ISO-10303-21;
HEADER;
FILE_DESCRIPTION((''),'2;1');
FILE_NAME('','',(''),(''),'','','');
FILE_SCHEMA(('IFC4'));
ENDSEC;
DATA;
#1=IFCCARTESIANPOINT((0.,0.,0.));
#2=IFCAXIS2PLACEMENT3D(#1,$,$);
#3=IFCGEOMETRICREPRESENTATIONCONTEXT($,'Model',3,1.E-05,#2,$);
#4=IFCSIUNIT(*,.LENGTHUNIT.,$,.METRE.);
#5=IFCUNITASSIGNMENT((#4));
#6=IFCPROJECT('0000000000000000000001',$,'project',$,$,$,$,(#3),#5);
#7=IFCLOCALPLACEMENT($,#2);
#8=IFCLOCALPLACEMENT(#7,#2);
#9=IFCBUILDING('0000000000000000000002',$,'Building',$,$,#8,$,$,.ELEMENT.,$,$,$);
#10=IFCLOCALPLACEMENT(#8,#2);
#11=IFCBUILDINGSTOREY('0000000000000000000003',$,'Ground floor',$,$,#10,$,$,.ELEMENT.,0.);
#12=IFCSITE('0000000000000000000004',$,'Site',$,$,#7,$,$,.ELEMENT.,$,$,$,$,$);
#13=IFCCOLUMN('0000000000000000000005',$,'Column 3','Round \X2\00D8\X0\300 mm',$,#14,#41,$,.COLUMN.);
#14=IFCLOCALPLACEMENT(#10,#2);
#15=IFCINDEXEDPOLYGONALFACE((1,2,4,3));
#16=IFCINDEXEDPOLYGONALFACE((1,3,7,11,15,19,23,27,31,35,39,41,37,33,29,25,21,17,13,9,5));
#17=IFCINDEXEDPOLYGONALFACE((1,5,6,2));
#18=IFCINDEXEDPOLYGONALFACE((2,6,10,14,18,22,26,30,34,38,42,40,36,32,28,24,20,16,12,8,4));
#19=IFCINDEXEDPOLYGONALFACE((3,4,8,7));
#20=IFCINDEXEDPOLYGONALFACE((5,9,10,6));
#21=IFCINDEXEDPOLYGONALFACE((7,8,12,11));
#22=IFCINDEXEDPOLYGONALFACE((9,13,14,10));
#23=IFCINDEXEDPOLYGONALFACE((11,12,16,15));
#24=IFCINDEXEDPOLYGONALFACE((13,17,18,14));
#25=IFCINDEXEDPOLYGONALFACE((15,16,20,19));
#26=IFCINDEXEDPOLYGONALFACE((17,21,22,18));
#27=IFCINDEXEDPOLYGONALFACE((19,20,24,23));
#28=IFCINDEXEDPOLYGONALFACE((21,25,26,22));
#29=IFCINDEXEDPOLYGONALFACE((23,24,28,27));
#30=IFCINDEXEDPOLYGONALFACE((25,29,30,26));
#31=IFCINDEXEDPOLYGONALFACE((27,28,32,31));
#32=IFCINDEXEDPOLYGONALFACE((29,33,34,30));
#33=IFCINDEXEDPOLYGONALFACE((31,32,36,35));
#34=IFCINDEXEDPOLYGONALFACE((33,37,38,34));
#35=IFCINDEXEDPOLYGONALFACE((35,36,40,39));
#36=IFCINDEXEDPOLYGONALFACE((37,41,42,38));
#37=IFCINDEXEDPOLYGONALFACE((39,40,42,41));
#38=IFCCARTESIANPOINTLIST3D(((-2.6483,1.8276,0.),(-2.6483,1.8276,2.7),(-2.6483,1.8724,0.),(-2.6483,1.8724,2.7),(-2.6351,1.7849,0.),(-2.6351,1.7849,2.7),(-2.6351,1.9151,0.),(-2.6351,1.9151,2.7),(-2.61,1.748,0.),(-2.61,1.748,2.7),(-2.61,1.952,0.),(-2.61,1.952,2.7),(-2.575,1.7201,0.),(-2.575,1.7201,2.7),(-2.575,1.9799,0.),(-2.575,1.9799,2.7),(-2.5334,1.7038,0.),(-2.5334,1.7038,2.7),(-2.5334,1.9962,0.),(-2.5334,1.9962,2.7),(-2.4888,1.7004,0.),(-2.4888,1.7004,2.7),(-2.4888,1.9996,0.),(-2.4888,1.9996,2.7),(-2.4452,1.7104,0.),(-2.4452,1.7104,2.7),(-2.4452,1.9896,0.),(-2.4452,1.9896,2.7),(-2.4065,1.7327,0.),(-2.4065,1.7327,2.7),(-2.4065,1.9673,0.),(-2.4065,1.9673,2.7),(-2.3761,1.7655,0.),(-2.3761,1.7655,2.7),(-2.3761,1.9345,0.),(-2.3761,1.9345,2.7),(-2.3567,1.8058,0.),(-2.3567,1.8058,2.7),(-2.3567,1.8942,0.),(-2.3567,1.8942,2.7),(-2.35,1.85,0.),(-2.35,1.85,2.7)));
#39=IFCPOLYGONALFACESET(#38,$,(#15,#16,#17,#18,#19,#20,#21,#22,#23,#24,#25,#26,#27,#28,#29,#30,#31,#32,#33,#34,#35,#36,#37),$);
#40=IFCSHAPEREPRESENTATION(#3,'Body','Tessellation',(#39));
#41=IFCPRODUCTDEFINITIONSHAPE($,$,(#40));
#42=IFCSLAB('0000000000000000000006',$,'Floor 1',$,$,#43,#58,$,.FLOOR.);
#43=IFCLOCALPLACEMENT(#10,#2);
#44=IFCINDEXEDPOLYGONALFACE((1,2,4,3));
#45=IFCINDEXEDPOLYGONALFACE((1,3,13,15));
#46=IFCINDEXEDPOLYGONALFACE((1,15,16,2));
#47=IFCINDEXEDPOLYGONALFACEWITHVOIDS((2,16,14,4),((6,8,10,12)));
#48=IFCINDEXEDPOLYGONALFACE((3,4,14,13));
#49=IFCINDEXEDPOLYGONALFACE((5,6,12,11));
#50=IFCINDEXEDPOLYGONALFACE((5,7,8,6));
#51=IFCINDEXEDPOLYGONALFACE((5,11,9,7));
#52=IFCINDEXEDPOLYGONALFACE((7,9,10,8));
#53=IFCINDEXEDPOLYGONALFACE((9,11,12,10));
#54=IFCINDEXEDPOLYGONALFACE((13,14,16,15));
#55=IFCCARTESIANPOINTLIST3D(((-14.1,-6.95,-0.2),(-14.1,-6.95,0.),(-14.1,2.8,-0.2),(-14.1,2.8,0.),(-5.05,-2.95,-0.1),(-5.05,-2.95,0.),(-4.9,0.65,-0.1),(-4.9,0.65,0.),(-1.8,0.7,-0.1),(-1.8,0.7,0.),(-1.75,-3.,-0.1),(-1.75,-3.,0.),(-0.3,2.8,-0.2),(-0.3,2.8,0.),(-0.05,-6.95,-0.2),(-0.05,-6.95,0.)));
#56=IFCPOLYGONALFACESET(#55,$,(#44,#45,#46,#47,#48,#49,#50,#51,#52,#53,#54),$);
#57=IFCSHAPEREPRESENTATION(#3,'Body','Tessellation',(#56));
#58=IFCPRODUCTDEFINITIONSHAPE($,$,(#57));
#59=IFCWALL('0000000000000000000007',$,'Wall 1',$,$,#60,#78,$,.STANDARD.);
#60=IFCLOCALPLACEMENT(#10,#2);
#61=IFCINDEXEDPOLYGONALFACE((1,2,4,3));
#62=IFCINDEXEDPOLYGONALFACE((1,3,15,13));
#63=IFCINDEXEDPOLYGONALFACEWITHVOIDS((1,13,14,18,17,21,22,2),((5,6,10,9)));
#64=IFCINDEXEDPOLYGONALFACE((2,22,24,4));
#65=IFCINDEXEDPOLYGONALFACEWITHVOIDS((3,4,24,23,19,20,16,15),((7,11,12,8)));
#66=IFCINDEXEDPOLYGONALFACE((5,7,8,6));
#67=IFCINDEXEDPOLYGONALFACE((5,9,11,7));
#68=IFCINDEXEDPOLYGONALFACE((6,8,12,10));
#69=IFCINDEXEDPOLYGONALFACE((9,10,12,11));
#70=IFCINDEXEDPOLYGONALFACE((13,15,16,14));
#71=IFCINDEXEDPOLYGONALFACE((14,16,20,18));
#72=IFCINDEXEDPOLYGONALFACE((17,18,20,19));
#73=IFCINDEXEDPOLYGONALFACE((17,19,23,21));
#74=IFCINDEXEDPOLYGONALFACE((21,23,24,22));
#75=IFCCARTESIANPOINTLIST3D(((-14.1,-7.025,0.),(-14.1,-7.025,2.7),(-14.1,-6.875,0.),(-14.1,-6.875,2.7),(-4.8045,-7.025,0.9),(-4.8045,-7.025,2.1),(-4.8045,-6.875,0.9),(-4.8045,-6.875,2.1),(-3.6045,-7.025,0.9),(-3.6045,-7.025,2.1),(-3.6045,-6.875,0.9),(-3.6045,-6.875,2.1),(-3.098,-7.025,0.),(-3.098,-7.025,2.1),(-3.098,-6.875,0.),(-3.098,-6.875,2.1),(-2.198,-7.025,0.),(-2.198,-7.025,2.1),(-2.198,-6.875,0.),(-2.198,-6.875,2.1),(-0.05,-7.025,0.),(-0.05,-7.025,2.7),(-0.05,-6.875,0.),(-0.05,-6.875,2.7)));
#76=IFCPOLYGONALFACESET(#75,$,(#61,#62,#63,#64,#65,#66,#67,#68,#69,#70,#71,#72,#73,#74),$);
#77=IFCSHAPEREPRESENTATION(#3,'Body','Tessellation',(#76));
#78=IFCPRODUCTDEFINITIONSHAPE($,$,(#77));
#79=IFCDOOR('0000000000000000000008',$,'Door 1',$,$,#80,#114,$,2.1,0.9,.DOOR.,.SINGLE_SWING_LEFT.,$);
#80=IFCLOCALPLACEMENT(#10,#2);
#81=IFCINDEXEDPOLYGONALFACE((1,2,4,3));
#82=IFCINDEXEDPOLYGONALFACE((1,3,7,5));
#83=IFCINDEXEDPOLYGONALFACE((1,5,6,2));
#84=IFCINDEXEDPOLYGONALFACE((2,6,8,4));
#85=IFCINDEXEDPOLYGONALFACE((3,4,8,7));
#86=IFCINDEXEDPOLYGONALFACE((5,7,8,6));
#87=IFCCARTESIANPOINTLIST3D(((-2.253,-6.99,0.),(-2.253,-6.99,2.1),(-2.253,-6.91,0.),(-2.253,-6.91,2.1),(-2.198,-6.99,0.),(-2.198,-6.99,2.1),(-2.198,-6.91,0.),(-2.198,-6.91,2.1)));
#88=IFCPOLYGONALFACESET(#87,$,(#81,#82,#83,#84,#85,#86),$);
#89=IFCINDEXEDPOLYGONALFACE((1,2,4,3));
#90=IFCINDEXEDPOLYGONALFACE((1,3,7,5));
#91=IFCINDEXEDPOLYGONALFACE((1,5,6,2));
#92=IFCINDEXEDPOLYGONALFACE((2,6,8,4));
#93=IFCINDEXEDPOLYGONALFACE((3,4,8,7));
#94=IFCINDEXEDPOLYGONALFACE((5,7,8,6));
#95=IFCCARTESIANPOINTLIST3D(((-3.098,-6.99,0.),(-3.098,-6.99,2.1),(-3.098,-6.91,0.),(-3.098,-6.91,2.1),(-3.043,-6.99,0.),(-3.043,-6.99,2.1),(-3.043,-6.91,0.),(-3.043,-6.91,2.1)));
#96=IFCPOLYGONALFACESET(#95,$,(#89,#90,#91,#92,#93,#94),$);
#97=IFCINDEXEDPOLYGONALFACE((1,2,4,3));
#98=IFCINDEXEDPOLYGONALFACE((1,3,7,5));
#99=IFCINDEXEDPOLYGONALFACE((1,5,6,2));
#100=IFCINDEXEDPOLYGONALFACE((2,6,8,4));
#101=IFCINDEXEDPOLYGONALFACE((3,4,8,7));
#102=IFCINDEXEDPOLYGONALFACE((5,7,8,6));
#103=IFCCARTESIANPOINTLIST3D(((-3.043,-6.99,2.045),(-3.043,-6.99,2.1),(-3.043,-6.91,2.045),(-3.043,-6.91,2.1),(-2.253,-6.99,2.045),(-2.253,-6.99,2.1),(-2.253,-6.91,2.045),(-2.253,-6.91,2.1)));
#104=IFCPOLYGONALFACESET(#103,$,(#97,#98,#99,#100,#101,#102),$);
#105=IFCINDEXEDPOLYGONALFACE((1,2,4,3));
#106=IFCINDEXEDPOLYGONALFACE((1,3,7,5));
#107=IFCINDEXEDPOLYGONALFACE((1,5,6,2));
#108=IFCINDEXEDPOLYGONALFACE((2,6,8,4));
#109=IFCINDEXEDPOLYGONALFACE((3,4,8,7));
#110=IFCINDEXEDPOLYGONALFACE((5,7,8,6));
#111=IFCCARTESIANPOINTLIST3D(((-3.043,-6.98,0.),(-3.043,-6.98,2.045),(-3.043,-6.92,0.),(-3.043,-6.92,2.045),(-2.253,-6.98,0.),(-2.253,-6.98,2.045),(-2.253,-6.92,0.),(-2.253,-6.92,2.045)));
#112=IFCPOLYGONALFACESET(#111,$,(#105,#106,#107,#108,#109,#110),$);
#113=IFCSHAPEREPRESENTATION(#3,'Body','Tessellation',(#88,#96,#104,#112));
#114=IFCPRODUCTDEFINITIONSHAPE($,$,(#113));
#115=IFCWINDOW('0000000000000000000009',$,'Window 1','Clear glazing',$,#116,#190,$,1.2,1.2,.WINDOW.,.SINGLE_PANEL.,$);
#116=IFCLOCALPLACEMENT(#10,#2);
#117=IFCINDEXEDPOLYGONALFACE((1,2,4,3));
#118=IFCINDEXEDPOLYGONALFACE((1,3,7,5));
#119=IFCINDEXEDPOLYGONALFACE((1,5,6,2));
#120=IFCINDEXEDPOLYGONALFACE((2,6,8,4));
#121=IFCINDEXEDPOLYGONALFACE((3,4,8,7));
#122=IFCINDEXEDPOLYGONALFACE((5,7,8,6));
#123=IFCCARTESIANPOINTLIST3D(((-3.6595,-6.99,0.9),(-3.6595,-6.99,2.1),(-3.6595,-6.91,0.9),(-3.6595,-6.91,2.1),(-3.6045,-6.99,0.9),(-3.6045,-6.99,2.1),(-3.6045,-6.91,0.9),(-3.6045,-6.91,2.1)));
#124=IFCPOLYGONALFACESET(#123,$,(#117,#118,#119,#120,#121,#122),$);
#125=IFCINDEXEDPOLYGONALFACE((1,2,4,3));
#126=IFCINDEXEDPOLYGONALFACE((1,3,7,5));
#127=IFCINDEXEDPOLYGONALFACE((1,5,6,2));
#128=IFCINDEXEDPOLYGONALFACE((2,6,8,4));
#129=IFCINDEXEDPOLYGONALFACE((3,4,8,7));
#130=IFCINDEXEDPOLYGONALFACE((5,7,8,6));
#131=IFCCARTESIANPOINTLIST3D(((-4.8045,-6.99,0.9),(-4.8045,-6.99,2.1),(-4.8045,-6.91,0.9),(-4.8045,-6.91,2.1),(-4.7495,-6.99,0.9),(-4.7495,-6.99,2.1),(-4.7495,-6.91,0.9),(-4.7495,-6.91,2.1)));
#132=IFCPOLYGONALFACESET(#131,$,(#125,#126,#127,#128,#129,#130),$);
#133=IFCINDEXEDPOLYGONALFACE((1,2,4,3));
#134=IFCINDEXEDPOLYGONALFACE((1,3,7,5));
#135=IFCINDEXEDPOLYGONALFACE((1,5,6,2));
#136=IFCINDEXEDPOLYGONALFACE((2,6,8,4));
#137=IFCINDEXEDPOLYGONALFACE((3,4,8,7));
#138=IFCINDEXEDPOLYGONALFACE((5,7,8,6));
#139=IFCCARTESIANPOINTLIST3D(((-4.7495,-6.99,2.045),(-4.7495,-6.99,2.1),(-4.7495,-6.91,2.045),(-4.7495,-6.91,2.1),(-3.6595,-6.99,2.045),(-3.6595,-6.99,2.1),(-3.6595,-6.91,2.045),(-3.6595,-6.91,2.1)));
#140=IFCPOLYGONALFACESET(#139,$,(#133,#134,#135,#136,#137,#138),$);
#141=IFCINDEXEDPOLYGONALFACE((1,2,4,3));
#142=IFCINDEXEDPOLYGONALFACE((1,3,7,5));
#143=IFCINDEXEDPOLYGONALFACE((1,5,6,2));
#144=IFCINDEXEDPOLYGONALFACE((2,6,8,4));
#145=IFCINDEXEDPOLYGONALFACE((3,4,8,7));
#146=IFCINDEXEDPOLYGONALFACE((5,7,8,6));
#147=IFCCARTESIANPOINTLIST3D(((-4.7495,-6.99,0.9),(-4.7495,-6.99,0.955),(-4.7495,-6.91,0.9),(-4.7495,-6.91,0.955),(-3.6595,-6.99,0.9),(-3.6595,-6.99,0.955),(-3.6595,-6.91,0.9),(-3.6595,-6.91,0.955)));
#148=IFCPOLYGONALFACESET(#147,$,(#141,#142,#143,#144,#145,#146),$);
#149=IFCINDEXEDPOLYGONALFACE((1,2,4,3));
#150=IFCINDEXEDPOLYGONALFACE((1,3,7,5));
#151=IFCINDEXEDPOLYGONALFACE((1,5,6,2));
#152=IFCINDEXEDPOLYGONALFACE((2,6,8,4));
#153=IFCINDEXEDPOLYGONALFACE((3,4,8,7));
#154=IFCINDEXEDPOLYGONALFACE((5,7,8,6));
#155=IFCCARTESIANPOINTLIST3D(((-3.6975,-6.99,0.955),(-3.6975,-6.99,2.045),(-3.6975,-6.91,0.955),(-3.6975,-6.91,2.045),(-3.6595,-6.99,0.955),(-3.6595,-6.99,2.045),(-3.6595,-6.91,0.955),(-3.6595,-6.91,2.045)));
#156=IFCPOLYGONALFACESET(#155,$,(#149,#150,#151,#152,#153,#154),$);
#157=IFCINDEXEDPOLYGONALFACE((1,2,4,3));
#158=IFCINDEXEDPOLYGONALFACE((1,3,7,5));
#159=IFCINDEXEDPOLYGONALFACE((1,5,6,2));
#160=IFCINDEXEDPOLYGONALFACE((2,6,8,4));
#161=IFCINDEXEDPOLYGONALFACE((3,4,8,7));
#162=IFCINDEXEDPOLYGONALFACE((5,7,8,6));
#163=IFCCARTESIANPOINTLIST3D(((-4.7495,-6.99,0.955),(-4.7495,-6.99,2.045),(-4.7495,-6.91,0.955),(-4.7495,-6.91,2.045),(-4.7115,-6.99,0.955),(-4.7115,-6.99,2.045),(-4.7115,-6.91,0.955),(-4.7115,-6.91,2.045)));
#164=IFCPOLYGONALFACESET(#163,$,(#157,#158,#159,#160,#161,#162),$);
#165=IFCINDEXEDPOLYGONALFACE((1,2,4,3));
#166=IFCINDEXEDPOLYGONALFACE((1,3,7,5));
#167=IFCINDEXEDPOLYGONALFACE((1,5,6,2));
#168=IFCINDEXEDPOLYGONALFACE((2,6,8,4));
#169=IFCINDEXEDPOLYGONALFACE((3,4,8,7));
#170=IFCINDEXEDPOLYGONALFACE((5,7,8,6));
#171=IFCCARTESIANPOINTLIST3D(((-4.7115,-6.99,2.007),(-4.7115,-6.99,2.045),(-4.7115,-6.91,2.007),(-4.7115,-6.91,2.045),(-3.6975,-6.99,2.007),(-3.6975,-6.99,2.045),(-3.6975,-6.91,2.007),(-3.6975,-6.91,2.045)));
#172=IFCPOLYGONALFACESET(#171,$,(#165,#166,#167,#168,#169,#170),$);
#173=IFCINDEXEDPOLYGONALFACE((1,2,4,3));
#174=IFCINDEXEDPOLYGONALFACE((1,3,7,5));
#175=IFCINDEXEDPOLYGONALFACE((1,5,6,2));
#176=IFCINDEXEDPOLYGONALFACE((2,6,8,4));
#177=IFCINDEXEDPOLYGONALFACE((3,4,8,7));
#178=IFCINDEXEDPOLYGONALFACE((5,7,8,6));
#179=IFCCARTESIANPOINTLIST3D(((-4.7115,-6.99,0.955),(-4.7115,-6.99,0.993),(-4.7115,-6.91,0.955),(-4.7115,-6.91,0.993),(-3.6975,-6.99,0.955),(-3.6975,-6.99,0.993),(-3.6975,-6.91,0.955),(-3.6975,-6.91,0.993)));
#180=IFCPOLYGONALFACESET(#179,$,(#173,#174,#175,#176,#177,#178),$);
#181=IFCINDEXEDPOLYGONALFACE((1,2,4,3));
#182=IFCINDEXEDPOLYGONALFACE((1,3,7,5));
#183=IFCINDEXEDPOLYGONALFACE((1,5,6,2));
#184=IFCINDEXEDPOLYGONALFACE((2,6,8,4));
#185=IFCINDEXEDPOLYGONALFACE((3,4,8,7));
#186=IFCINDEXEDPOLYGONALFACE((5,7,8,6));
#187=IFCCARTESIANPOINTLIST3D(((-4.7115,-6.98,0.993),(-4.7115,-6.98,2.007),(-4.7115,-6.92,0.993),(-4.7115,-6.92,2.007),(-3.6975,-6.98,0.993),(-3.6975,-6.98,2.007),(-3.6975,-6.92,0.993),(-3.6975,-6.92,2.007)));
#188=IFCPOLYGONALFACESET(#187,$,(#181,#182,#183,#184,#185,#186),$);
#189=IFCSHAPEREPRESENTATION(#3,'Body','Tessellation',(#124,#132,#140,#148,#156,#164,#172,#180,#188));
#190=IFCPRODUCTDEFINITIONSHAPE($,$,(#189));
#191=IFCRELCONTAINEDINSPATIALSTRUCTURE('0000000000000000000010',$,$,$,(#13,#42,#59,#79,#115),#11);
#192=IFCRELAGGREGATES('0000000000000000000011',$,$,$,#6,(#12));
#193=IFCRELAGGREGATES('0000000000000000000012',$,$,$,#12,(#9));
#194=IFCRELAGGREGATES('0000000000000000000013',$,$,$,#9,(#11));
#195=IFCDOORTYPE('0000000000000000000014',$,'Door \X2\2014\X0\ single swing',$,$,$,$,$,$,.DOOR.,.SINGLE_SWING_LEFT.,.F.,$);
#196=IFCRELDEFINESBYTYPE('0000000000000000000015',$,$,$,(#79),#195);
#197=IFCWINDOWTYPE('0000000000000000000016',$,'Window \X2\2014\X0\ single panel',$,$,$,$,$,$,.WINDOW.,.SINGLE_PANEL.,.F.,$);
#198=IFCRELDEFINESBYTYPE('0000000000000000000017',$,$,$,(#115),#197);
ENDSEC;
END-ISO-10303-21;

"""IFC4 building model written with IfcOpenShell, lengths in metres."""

from ifc_helpers import new_model, si_unit, frame, frame_2d, origin, origin_2d, place, context, project, spatial, polyline, rectangle, circle, outline, extrude, type_object, element, fill, save


model = new_model("IFC4")

# Units and contexts
model_context = context("Model", 3, precision=1e-05, world=origin())
ifc_project = project(units=[si_unit("LENGTHUNIT", "METRE")], contexts=[model_context])

# Site, building, storey
site_placement = place(None, origin())
site = spatial("IfcSite", under=ifc_project, at=site_placement, Name="Site", CompositionType="ELEMENT")
building_placement = place(site_placement, origin())
building = spatial("IfcBuilding", under=site, at=building_placement, Name="Building", CompositionType="ELEMENT")
storey_placement = place(building_placement, origin())
storey = spatial("IfcBuildingStorey", under=building, at=storey_placement, Name="Ground floor", CompositionType="ELEMENT", Elevation=0.0)

# Column
column_placement = place(storey_placement, frame((-2.5, 1.85, 0.0), z_axis=(0.0, 0.0, 1.0), x_axis=(1.0, 0.0, 0.0)))
element("IfcColumn", 1, at=column_placement, inside=storey, Name="Column 3", Description="Round Ø300 mm", PredefinedType="COLUMN", context=model_context, shape_type="SweptSolid", body=[
    extrude(circle(Radius=0.15, at=origin_2d()), origin(), (0.0, 0.0, 1.0), 2.7),
])

# Slab, opening
slab_placement = place(storey_placement, frame((0.0, 0.0, -0.2), z_axis=(0.0, 0.0, 1.0), x_axis=(1.0, 0.0, 0.0)))
slab = element("IfcSlab", 2, at=slab_placement, inside=storey, Name="Floor 1", PredefinedType="FLOOR", context=model_context, shape_type="SweptSolid", body=[
    extrude(outline(polyline([(-14.1, 2.8), (-14.1, -6.95), (-0.05, -6.95), (-0.3, 2.8), (-14.1, 2.8)])), origin(), (0.0, 0.0, 1.0), 0.2),
])
opening_1_placement = place(storey_placement, frame((0.0, 0.0, -0.2), z_axis=(0.0, 0.0, 1.0), x_axis=(1.0, 0.0, 0.0)))
element("IfcOpeningElement", 3, at=opening_1_placement, cuts=slab, PredefinedType="RECESS", context=model_context, shape_type="SweptSolid", body=[
    extrude(outline(polyline([(-4.9, 0.65), (-5.05, -2.95), (-1.75, -3.0), (-1.8, 0.7), (-4.9, 0.65)])), frame((0.0, 0.0, 0.1)), (0.0, 0.0, 1.0), 0.12),
])

# Wall, openings, door, window
wall_1_placement = place(storey_placement, frame((-0.05, -6.95, 0.0), z_axis=(0.0, 0.0, 1.0), x_axis=(-1.0, 0.0, 0.0)))
wall_1 = element("IfcWall", 4, at=wall_1_placement, inside=storey, Name="Wall 1", PredefinedType="STANDARD", context=model_context, shape_type="SweptSolid", body=[
    extrude(rectangle(XDim=14.05, YDim=0.15, at=frame_2d((7.025, 0.0))), origin(), (0.0, 0.0, 1.0), 2.7),
])
opening_2_placement = place(storey_placement, frame((-3.6045, -6.95, 0.9), z_axis=(0.0, 0.0, 1.0), x_axis=(-1.0, 0.0, 0.0)))
opening_2 = element("IfcOpeningElement", 5, at=opening_2_placement, cuts=wall_1, PredefinedType="OPENING", context=model_context, shape_type="SweptSolid", body=[
    extrude(rectangle(XDim=1.2, YDim=0.21, at=frame_2d((0.6, 0.0))), origin(), (0.0, 0.0, 1.0), 1.2),
])
opening_3_placement = place(storey_placement, frame((-2.198, -6.95, 0.0), z_axis=(0.0, 0.0, 1.0), x_axis=(-1.0, 0.0, 0.0)))
opening_3 = element("IfcOpeningElement", 6, at=opening_3_placement, cuts=wall_1, PredefinedType="OPENING", context=model_context, shape_type="SweptSolid", body=[
    extrude(rectangle(XDim=0.9, YDim=0.21, at=frame_2d((0.45, 0.0))), origin(), (0.0, 0.0, 1.0), 2.1),
])
door_type = type_object("IfcDoorType", Name="Door — single swing", OperationType="SINGLE_SWING_LEFT", ParameterTakesPrecedence=False, PredefinedType="DOOR")
door_1_placement = place(storey_placement, frame((-2.198, -6.95, 0.0), z_axis=(0.0, 0.0, 1.0), x_axis=(-1.0, 0.0, 0.0)))
door_1 = element("IfcDoor", 7, at=door_1_placement, inside=storey, type_object=door_type, Name="Door 1", OperationType="SINGLE_SWING_LEFT", OverallHeight=2.1, OverallWidth=0.9, PredefinedType="DOOR", context=model_context, shape_type="SweptSolid", body=[
    extrude(rectangle(XDim=0.055, YDim=0.08, at=frame_2d((0.0275, 0.0))), origin(), (0.0, 0.0, 1.0), 2.1),
    extrude(rectangle(XDim=0.055, YDim=0.08, at=frame_2d((0.8725, 0.0))), origin(), (0.0, 0.0, 1.0), 2.1),
    extrude(rectangle(XDim=0.79, YDim=0.08, at=frame_2d((0.45, 0.0))), frame((0.0, 0.0, 2.045)), (0.0, 0.0, 1.0), 0.055),
    extrude(rectangle(XDim=0.79, YDim=0.06, at=frame_2d((0.45, 0.0))), origin(), (0.0, 0.0, 1.0), 2.045),
])
fill(opening_3, door_1)
window_type_1 = type_object("IfcWindowType", Name="Window — single panel", ParameterTakesPrecedence=False, PartitioningType="SINGLE_PANEL", PredefinedType="WINDOW")
window_1_placement = place(storey_placement, frame((-3.6045, -6.95, 0.9), z_axis=(0.0, 0.0, 1.0), x_axis=(-1.0, 0.0, 0.0)))
window_1 = element("IfcWindow", 8, at=window_1_placement, inside=storey, type_object=window_type_1, Name="Window 1", Description="Clear glazing", OverallHeight=1.2, OverallWidth=1.2, PartitioningType="SINGLE_PANEL", PredefinedType="WINDOW", context=model_context, shape_type="SweptSolid", body=[
    extrude(rectangle(XDim=0.055, YDim=0.08, at=frame_2d((0.0275, 0.0))), origin(), (0.0, 0.0, 1.0), 1.2),
    extrude(rectangle(XDim=0.055, YDim=0.08, at=frame_2d((1.1725, 0.0))), origin(), (0.0, 0.0, 1.0), 1.2),
    extrude(rectangle(XDim=1.09, YDim=0.08, at=frame_2d((0.6, 0.0))), frame((0.0, 0.0, 1.145)), (0.0, 0.0, 1.0), 0.055),
    extrude(rectangle(XDim=1.09, YDim=0.08, at=frame_2d((0.6, 0.0))), origin(), (0.0, 0.0, 1.0), 0.055),
    extrude(rectangle(XDim=0.038, YDim=0.08, at=frame_2d((0.074, 0.0))), frame((0.0, 0.0, 0.055)), (0.0, 0.0, 1.0), 1.09),
    extrude(rectangle(XDim=0.038, YDim=0.08, at=frame_2d((1.126, 0.0))), frame((0.0, 0.0, 0.055)), (0.0, 0.0, 1.0), 1.09),
    extrude(rectangle(XDim=1.014, YDim=0.08, at=frame_2d((0.6, 0.0))), frame((0.0, 0.0, 1.107)), (0.0, 0.0, 1.0), 0.038),
    extrude(rectangle(XDim=1.014, YDim=0.08, at=frame_2d((0.6, 0.0))), frame((0.0, 0.0, 0.055)), (0.0, 0.0, 1.0), 0.038),
    extrude(rectangle(XDim=1.014, YDim=0.06, at=frame_2d((0.6, 0.0))), frame((0.0, 0.0, 0.093)), (0.0, 0.0, 1.0), 1.014),
])
fill(opening_2, window_1)

save(model, "model.ifc")
